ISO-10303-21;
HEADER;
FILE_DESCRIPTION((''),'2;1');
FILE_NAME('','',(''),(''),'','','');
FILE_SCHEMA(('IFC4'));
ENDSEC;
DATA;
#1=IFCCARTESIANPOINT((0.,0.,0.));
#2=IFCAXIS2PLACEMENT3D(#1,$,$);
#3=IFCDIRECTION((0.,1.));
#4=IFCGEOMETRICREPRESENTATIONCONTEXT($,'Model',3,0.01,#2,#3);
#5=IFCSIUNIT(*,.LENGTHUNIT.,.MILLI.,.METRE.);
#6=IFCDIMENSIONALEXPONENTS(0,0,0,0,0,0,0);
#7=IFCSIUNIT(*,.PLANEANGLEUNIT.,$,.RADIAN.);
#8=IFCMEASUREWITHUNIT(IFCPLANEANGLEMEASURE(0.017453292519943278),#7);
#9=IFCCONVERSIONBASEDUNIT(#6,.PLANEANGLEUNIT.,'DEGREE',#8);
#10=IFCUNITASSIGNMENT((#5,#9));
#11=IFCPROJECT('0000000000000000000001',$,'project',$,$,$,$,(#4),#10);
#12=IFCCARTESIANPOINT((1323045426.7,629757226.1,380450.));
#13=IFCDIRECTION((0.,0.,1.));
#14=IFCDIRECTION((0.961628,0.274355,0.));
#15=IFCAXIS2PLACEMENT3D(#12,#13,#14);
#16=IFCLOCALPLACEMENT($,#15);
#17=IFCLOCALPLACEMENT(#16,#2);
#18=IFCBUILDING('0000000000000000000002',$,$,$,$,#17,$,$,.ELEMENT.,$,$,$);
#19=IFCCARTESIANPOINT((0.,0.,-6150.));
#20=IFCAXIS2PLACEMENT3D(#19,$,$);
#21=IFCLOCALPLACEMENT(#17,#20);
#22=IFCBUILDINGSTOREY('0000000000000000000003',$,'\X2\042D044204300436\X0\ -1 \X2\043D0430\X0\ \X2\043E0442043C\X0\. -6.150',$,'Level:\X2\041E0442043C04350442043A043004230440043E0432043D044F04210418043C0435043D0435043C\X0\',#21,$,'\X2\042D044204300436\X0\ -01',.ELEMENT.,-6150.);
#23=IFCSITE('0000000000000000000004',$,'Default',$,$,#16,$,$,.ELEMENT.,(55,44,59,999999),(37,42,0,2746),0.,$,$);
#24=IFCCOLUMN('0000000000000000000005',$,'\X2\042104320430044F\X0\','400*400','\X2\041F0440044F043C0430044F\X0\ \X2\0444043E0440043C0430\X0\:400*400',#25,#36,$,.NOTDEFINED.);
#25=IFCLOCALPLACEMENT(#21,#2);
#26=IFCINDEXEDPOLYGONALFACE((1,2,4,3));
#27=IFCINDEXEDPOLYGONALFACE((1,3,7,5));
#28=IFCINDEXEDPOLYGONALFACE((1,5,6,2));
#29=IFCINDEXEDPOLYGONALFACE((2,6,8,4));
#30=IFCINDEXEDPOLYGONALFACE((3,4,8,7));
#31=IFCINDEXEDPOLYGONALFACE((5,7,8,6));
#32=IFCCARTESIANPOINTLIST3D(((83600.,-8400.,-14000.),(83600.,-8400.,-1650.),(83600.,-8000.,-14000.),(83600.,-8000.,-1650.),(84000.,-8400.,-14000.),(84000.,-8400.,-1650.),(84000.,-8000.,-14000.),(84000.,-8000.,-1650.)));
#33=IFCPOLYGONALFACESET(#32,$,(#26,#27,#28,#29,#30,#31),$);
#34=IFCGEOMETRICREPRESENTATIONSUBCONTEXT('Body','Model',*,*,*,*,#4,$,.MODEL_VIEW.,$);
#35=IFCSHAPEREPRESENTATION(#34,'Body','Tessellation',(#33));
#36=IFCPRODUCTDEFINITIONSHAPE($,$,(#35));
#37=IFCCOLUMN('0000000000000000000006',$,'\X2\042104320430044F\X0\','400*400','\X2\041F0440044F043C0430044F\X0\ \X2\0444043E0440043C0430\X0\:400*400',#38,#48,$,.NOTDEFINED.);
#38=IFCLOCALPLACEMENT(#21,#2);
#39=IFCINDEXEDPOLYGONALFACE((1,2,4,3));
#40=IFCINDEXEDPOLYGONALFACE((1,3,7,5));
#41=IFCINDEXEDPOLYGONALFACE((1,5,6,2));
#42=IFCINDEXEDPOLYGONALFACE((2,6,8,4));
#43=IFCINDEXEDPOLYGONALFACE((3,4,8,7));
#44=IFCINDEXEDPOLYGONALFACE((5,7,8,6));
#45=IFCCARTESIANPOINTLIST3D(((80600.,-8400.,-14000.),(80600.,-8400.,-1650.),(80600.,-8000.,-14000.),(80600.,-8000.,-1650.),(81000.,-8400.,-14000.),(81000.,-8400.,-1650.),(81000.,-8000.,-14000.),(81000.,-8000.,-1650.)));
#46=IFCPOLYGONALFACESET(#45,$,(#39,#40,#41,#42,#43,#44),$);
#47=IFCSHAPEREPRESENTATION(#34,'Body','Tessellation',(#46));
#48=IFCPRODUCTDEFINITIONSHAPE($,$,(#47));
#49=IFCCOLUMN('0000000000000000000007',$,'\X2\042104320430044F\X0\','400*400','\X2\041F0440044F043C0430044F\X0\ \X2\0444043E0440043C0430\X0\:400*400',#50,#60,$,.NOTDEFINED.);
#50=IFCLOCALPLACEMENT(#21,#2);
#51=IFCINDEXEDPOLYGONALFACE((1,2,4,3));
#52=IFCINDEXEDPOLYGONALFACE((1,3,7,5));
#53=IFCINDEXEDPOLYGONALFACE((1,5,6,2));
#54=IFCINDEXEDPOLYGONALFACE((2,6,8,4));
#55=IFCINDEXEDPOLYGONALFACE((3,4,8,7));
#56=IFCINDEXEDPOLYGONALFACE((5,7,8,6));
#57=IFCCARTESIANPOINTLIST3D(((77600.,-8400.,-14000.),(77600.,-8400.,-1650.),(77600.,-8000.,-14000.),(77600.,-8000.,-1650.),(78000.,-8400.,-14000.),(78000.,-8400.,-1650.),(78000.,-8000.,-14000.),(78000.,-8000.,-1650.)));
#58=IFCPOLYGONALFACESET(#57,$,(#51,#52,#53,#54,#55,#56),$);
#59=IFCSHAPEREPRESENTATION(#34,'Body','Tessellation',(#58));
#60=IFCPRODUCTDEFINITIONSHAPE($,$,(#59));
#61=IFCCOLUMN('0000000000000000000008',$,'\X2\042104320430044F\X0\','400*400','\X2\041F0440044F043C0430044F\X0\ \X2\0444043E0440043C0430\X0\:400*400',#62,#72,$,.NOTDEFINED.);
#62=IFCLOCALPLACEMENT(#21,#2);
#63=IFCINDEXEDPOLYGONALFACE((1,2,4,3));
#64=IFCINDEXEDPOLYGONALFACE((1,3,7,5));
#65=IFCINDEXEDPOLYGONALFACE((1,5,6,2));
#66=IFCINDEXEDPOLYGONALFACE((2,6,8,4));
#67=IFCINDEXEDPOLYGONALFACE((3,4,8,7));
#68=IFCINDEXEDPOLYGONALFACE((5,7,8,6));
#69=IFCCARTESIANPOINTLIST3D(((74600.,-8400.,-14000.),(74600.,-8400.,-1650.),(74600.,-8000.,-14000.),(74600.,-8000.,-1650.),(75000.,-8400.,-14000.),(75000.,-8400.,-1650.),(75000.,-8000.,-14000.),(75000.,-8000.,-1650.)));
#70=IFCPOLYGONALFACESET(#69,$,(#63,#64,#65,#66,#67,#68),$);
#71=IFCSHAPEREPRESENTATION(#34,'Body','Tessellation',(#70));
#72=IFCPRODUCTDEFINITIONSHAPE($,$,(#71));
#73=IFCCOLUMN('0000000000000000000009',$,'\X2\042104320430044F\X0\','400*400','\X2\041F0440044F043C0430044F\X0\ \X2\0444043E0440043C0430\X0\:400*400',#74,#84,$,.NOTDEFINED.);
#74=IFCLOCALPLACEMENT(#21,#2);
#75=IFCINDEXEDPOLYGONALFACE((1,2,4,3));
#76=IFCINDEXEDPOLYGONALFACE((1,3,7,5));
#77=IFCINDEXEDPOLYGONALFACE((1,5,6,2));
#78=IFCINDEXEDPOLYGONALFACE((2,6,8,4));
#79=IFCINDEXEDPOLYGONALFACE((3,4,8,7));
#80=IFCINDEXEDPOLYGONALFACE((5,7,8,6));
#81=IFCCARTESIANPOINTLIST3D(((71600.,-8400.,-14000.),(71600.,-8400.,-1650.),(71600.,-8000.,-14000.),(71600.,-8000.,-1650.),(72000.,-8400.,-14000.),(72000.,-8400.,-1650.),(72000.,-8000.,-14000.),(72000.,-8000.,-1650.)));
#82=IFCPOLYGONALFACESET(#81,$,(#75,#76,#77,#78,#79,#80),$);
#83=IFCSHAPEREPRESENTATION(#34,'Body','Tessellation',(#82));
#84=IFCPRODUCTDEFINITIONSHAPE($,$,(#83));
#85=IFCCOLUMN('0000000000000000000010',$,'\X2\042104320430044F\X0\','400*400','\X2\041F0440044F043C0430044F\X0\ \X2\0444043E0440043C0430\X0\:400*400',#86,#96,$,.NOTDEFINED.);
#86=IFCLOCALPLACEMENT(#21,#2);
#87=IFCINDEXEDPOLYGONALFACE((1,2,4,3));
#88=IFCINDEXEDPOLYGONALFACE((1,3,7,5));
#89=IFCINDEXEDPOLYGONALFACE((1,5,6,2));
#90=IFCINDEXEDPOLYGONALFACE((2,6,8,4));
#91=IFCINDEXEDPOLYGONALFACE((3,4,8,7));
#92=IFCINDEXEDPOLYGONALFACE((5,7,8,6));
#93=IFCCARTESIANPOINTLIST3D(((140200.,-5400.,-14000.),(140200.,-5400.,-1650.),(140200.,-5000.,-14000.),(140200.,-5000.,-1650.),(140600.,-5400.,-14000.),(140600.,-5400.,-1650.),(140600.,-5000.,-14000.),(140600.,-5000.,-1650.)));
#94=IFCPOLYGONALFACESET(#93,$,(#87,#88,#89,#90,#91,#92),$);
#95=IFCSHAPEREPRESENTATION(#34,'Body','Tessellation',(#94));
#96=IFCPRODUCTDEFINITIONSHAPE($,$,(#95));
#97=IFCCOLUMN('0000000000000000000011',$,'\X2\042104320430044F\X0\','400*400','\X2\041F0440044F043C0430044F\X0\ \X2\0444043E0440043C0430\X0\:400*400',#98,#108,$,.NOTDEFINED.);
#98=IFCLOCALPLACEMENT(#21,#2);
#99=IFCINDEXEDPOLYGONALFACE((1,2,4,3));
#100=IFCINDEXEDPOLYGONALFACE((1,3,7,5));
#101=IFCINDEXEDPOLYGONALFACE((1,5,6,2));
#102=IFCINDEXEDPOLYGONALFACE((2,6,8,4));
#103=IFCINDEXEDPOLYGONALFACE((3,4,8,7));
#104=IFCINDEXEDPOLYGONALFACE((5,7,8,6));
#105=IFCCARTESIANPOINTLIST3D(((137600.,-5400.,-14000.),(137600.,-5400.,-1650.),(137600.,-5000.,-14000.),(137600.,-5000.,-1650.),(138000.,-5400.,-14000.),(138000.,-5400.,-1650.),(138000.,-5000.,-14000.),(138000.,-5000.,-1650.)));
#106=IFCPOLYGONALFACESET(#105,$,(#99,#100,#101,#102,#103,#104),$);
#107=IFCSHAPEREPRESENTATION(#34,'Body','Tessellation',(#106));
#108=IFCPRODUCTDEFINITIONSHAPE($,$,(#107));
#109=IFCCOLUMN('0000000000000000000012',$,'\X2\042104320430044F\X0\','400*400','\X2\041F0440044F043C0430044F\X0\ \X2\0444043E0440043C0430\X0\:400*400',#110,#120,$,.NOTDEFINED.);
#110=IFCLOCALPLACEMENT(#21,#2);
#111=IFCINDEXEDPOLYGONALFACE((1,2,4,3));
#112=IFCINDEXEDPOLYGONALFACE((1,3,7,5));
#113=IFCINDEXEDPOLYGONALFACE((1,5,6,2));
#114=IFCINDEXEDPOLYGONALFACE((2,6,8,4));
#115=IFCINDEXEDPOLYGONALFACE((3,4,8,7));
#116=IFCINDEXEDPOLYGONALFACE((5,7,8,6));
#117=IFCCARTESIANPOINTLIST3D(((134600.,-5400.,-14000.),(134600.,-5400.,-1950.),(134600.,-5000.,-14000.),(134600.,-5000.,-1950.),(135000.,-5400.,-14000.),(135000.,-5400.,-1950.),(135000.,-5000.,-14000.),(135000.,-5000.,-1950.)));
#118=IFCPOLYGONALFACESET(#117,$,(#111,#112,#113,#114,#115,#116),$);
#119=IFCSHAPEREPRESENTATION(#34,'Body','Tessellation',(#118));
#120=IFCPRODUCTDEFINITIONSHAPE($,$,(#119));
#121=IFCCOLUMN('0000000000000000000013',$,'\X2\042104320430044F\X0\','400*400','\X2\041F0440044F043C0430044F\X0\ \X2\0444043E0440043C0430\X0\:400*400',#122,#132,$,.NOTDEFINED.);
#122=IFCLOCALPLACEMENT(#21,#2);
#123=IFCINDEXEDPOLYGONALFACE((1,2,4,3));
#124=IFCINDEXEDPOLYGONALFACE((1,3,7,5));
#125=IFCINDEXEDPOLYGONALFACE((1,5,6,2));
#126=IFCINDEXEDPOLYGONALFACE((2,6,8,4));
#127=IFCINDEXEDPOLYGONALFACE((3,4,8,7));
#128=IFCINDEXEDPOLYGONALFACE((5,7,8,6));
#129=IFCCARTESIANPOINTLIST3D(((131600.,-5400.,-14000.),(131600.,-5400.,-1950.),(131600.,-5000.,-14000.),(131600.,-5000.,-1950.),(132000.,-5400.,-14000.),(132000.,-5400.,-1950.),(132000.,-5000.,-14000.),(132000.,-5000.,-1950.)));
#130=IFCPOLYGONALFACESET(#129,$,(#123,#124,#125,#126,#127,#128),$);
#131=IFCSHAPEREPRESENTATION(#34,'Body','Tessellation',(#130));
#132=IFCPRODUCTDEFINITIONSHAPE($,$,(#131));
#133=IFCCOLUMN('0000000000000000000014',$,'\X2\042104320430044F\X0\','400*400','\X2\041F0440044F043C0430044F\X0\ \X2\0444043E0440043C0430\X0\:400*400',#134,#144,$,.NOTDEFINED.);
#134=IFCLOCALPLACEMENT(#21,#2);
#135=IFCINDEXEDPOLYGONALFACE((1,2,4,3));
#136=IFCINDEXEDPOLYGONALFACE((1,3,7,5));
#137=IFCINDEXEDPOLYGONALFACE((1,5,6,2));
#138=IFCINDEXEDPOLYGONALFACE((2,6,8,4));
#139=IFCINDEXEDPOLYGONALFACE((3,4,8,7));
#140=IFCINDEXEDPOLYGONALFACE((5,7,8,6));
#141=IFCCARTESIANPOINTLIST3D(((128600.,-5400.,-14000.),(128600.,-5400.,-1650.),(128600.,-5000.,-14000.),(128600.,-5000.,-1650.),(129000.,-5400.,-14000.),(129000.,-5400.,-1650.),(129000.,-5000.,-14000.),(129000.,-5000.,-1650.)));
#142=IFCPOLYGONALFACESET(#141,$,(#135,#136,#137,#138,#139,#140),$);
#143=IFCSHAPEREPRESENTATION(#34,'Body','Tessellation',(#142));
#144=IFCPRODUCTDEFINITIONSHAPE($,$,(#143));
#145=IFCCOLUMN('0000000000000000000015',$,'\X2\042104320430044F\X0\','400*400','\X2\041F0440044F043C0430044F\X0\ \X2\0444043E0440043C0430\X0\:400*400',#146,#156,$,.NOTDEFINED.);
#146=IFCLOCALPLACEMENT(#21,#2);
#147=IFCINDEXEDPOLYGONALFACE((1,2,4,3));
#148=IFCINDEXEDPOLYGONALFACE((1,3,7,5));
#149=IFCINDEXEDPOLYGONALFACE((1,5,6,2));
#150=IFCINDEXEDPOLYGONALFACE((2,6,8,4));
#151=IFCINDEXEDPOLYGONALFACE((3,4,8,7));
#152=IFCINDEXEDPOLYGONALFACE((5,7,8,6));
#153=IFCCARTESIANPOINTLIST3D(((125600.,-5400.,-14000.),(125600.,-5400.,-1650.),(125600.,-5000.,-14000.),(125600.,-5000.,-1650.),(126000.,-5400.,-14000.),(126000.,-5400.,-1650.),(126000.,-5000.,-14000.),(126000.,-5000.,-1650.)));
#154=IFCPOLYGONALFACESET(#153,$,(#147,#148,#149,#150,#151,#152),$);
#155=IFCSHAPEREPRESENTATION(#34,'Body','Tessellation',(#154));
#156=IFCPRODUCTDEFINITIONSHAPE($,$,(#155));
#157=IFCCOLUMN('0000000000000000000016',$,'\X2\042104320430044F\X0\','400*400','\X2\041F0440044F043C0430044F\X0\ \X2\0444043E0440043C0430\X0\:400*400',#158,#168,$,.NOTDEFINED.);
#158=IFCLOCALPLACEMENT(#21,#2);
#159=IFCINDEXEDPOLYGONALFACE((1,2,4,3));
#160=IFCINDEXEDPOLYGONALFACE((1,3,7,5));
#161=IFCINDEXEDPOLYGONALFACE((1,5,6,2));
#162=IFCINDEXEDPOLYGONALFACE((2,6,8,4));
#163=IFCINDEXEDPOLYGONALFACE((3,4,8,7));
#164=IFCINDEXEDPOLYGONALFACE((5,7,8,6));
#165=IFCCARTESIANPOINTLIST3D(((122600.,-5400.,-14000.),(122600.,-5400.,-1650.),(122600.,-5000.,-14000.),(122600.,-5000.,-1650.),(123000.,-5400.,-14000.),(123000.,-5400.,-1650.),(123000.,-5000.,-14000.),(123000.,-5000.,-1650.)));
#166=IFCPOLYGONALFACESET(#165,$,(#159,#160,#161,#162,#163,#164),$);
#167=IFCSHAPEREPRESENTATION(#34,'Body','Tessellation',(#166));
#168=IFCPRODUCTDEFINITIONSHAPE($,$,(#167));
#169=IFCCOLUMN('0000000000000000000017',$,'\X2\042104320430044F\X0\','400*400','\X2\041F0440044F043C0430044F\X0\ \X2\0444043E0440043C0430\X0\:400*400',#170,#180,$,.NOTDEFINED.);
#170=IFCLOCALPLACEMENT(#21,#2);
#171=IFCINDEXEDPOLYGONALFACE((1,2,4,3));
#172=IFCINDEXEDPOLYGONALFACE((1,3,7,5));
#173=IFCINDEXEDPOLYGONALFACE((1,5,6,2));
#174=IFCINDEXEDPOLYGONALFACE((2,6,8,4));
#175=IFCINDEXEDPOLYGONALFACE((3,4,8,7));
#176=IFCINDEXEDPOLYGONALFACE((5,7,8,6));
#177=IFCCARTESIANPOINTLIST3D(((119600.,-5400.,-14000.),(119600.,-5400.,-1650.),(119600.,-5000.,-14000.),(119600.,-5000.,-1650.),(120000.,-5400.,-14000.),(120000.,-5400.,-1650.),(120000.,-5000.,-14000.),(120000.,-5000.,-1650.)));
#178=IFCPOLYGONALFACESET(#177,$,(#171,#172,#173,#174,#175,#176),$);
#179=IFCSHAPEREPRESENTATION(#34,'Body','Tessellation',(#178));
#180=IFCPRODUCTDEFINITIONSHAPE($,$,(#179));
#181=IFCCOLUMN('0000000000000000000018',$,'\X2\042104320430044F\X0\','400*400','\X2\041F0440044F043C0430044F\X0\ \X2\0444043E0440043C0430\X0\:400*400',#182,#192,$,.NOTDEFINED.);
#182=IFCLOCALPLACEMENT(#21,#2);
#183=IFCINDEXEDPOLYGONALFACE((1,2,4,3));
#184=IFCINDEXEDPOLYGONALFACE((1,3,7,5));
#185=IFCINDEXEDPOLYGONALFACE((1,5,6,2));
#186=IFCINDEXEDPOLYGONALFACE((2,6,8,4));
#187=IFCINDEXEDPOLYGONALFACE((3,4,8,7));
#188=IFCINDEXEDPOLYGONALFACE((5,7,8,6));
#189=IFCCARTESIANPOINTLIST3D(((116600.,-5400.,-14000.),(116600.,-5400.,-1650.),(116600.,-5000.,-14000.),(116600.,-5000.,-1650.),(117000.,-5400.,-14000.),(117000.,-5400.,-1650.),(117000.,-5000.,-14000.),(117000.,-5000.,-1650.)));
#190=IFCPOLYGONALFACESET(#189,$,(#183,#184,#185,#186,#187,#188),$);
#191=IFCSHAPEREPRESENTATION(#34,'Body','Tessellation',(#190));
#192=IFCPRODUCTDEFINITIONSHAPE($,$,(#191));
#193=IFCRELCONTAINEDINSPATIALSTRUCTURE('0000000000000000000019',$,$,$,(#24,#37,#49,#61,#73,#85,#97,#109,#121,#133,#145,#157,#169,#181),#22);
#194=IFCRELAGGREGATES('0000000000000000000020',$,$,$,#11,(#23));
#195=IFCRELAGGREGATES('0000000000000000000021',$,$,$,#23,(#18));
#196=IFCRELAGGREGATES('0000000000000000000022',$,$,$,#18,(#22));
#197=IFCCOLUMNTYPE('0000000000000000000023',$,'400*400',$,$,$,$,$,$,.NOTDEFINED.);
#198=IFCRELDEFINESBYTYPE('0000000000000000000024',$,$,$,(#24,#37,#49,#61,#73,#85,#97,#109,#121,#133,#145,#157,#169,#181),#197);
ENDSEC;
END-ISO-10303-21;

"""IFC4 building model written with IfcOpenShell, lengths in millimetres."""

from ifc_helpers import new_model, entity, si_unit, converted_unit, direction, frame, origin, place, context, subcontext, project, spatial, indexed_curve, outline, extrude, type_object, element, save


model = new_model("IFC4")

# Units and contexts
model_context = context("Model", 3, precision=0.01, world=origin(), true_north=direction((0.0, 1.0)))
body_context = subcontext(model_context, "Body", "Model", "MODEL_VIEW")
ifc_project = project(units=[si_unit("LENGTHUNIT", "METRE", prefix="MILLI"), converted_unit("PLANEANGLEUNIT", "DEGREE", entity("IfcPlaneAngleMeasure", 0.017453292519943278), si_unit("PLANEANGLEUNIT", "RADIAN"), dimensions=[0, 0, 0, 0, 0, 0, 0])], contexts=[model_context])

# Site, building, storey
site_placement = place(None, frame((1323045426.7, 629757226.1, 380450.0), z_axis=(0.0, 0.0, 1.0), x_axis=(0.961628, 0.274355, 0.0)))
site = spatial("IfcSite", under=ifc_project, at=site_placement, Name="Default", CompositionType="ELEMENT", RefLatitude=(55, 44, 59, 999999), RefLongitude=(37, 42, 0, 2746), RefElevation=0.0)
building_placement = place(site_placement, origin())
building = spatial("IfcBuilding", under=site, at=building_placement, CompositionType="ELEMENT")
storey_placement = place(building_placement, frame((0.0, 0.0, -6150.0)))
storey = spatial("IfcBuildingStorey", under=building, at=storey_placement, Name="Этаж -1 на отм. -6.150", ObjectType="Level:ОтметкаУровняСИменем", LongName="Этаж -01", CompositionType="ELEMENT", Elevation=-6150.0)

# Columns
column_type = type_object("IfcColumnType", Name="400*400", PredefinedType="NOTDEFINED")
column_1_placement = place(storey_placement, origin())
element("IfcColumn", 1, at=column_1_placement, inside=storey, type_object=column_type, Name="Свая", Description="400*400", ObjectType="Прямая форма:400*400", PredefinedType="NOTDEFINED", context=body_context, shape_type="SweptSolid", body=[
    extrude(outline(indexed_curve([(-200.0, -200.0), (200.0, -200.0), (200.0, 200.0), (-200.0, 200.0), (-200.0, -200.0)], self_intersect=False)), frame((83800.0, -8200.0, -14000.0), z_axis=(0.0, 0.0, 1.0), x_axis=(0.0, 1.0, 0.0)), (0.0, 0.0, 1.0), 12350.0),
])
column_2_placement = place(storey_placement, origin())
element("IfcColumn", 2, at=column_2_placement, inside=storey, type_object=column_type, Name="Свая", Description="400*400", ObjectType="Прямая форма:400*400", PredefinedType="NOTDEFINED", context=body_context, shape_type="SweptSolid", body=[
    extrude(outline(indexed_curve([(-200.0, -200.0), (200.0, -200.0), (200.0, 200.0), (-200.0, 200.0), (-200.0, -200.0)], self_intersect=False)), frame((80800.0, -8200.0, -14000.0), z_axis=(0.0, 0.0, 1.0), x_axis=(0.0, 1.0, 0.0)), (0.0, 0.0, 1.0), 12350.0),
])
column_3_placement = place(storey_placement, origin())
element("IfcColumn", 3, at=column_3_placement, inside=storey, type_object=column_type, Name="Свая", Description="400*400", ObjectType="Прямая форма:400*400", PredefinedType="NOTDEFINED", context=body_context, shape_type="SweptSolid", body=[
    extrude(outline(indexed_curve([(-200.0, -200.0), (200.0, -200.0), (200.0, 200.0), (-200.0, 200.0), (-200.0, -200.0)], self_intersect=False)), frame((77800.0, -8200.0, -14000.0), z_axis=(0.0, 0.0, 1.0), x_axis=(0.0, 1.0, 0.0)), (0.0, 0.0, 1.0), 12350.0),
])
column_4_placement = place(storey_placement, origin())
element("IfcColumn", 4, at=column_4_placement, inside=storey, type_object=column_type, Name="Свая", Description="400*400", ObjectType="Прямая форма:400*400", PredefinedType="NOTDEFINED", context=body_context, shape_type="SweptSolid", body=[
    extrude(outline(indexed_curve([(-200.0, -200.0), (200.0, -200.0), (200.0, 200.0), (-200.0, 200.0), (-200.0, -200.0)], self_intersect=False)), frame((74800.0, -8200.0, -14000.0), z_axis=(0.0, 0.0, 1.0), x_axis=(0.0, 1.0, 0.0)), (0.0, 0.0, 1.0), 12350.0),
])
column_5_placement = place(storey_placement, origin())
element("IfcColumn", 5, at=column_5_placement, inside=storey, type_object=column_type, Name="Свая", Description="400*400", ObjectType="Прямая форма:400*400", PredefinedType="NOTDEFINED", context=body_context, shape_type="SweptSolid", body=[
    extrude(outline(indexed_curve([(-200.0, -200.0), (200.0, -200.0), (200.0, 200.0), (-200.0, 200.0), (-200.0, -200.0)], self_intersect=False)), frame((71800.0, -8200.0, -14000.0), z_axis=(0.0, 0.0, 1.0), x_axis=(0.0, 1.0, 0.0)), (0.0, 0.0, 1.0), 12350.0),
])
column_6_placement = place(storey_placement, origin())
element("IfcColumn", 6, at=column_6_placement, inside=storey, type_object=column_type, Name="Свая", Description="400*400", ObjectType="Прямая форма:400*400", PredefinedType="NOTDEFINED", context=body_context, shape_type="SweptSolid", body=[
    extrude(outline(indexed_curve([(-200.0, -200.0), (200.0, -200.0), (200.0, 200.0), (-200.0, 200.0), (-200.0, -200.0)], self_intersect=False)), frame((140400.0, -5200.0, -14000.0), z_axis=(0.0, 0.0, 1.0), x_axis=(0.0, 1.0, 0.0)), (0.0, 0.0, 1.0), 12350.0),
])
column_7_placement = place(storey_placement, origin())
element("IfcColumn", 7, at=column_7_placement, inside=storey, type_object=column_type, Name="Свая", Description="400*400", ObjectType="Прямая форма:400*400", PredefinedType="NOTDEFINED", context=body_context, shape_type="SweptSolid", body=[
    extrude(outline(indexed_curve([(-200.0, -200.0), (200.0, -200.0), (200.0, 200.0), (-200.0, 200.0), (-200.0, -200.0)], self_intersect=False)), frame((137800.0, -5200.0, -14000.0), z_axis=(0.0, 0.0, 1.0), x_axis=(0.0, 1.0, 0.0)), (0.0, 0.0, 1.0), 12350.0),
])
column_8_placement = place(storey_placement, origin())
element("IfcColumn", 8, at=column_8_placement, inside=storey, type_object=column_type, Name="Свая", Description="400*400", ObjectType="Прямая форма:400*400", PredefinedType="NOTDEFINED", context=body_context, shape_type="SweptSolid", body=[
    extrude(outline(indexed_curve([(-200.0, -200.0), (200.0, -200.0), (200.0, 200.0), (-200.0, 200.0), (-200.0, -200.0)], self_intersect=False)), frame((134800.0, -5200.0, -14000.0), z_axis=(0.0, 0.0, 1.0), x_axis=(0.0, 1.0, 0.0)), (0.0, 0.0, 1.0), 12050.0),
])
column_9_placement = place(storey_placement, origin())
element("IfcColumn", 9, at=column_9_placement, inside=storey, type_object=column_type, Name="Свая", Description="400*400", ObjectType="Прямая форма:400*400", PredefinedType="NOTDEFINED", context=body_context, shape_type="SweptSolid", body=[
    extrude(outline(indexed_curve([(-200.0, -200.0), (200.0, -200.0), (200.0, 200.0), (-200.0, 200.0), (-200.0, -200.0)], self_intersect=False)), frame((131800.0, -5200.0, -14000.0), z_axis=(0.0, 0.0, 1.0), x_axis=(0.0, 1.0, 0.0)), (0.0, 0.0, 1.0), 12050.0),
])
column_10_placement = place(storey_placement, origin())
element("IfcColumn", 10, at=column_10_placement, inside=storey, type_object=column_type, Name="Свая", Description="400*400", ObjectType="Прямая форма:400*400", PredefinedType="NOTDEFINED", context=body_context, shape_type="SweptSolid", body=[
    extrude(outline(indexed_curve([(-200.0, -200.0), (200.0, -200.0), (200.0, 200.0), (-200.0, 200.0), (-200.0, -200.0)], self_intersect=False)), frame((128800.0, -5200.0, -14000.0), z_axis=(0.0, 0.0, 1.0), x_axis=(0.0, 1.0, 0.0)), (0.0, 0.0, 1.0), 12350.0),
])
column_11_placement = place(storey_placement, origin())
element("IfcColumn", 11, at=column_11_placement, inside=storey, type_object=column_type, Name="Свая", Description="400*400", ObjectType="Прямая форма:400*400", PredefinedType="NOTDEFINED", context=body_context, shape_type="SweptSolid", body=[
    extrude(outline(indexed_curve([(-200.0, -200.0), (200.0, -200.0), (200.0, 200.0), (-200.0, 200.0), (-200.0, -200.0)], self_intersect=False)), frame((125800.0, -5200.0, -14000.0), z_axis=(0.0, 0.0, 1.0), x_axis=(0.0, 1.0, 0.0)), (0.0, 0.0, 1.0), 12350.0),
])
column_12_placement = place(storey_placement, origin())
element("IfcColumn", 12, at=column_12_placement, inside=storey, type_object=column_type, Name="Свая", Description="400*400", ObjectType="Прямая форма:400*400", PredefinedType="NOTDEFINED", context=body_context, shape_type="SweptSolid", body=[
    extrude(outline(indexed_curve([(-200.0, -200.0), (200.0, -200.0), (200.0, 200.0), (-200.0, 200.0), (-200.0, -200.0)], self_intersect=False)), frame((122800.0, -5200.0, -14000.0), z_axis=(0.0, 0.0, 1.0), x_axis=(0.0, 1.0, 0.0)), (0.0, 0.0, 1.0), 12350.0),
])
column_13_placement = place(storey_placement, origin())
element("IfcColumn", 13, at=column_13_placement, inside=storey, type_object=column_type, Name="Свая", Description="400*400", ObjectType="Прямая форма:400*400", PredefinedType="NOTDEFINED", context=body_context, shape_type="SweptSolid", body=[
    extrude(outline(indexed_curve([(-200.0, -200.0), (200.0, -200.0), (200.0, 200.0), (-200.0, 200.0), (-200.0, -200.0)], self_intersect=False)), frame((119800.0, -5200.0, -14000.0), z_axis=(0.0, 0.0, 1.0), x_axis=(0.0, 1.0, 0.0)), (0.0, 0.0, 1.0), 12350.0),
])
column_14_placement = place(storey_placement, origin())
element("IfcColumn", 14, at=column_14_placement, inside=storey, type_object=column_type, Name="Свая", Description="400*400", ObjectType="Прямая форма:400*400", PredefinedType="NOTDEFINED", context=body_context, shape_type="SweptSolid", body=[
    extrude(outline(indexed_curve([(-200.0, -200.0), (200.0, -200.0), (200.0, 200.0), (-200.0, 200.0), (-200.0, -200.0)], self_intersect=False)), frame((116800.0, -5200.0, -14000.0), z_axis=(0.0, 0.0, 1.0), x_axis=(0.0, 1.0, 0.0)), (0.0, 0.0, 1.0), 12350.0),
])

save(model, "model.ifc")
